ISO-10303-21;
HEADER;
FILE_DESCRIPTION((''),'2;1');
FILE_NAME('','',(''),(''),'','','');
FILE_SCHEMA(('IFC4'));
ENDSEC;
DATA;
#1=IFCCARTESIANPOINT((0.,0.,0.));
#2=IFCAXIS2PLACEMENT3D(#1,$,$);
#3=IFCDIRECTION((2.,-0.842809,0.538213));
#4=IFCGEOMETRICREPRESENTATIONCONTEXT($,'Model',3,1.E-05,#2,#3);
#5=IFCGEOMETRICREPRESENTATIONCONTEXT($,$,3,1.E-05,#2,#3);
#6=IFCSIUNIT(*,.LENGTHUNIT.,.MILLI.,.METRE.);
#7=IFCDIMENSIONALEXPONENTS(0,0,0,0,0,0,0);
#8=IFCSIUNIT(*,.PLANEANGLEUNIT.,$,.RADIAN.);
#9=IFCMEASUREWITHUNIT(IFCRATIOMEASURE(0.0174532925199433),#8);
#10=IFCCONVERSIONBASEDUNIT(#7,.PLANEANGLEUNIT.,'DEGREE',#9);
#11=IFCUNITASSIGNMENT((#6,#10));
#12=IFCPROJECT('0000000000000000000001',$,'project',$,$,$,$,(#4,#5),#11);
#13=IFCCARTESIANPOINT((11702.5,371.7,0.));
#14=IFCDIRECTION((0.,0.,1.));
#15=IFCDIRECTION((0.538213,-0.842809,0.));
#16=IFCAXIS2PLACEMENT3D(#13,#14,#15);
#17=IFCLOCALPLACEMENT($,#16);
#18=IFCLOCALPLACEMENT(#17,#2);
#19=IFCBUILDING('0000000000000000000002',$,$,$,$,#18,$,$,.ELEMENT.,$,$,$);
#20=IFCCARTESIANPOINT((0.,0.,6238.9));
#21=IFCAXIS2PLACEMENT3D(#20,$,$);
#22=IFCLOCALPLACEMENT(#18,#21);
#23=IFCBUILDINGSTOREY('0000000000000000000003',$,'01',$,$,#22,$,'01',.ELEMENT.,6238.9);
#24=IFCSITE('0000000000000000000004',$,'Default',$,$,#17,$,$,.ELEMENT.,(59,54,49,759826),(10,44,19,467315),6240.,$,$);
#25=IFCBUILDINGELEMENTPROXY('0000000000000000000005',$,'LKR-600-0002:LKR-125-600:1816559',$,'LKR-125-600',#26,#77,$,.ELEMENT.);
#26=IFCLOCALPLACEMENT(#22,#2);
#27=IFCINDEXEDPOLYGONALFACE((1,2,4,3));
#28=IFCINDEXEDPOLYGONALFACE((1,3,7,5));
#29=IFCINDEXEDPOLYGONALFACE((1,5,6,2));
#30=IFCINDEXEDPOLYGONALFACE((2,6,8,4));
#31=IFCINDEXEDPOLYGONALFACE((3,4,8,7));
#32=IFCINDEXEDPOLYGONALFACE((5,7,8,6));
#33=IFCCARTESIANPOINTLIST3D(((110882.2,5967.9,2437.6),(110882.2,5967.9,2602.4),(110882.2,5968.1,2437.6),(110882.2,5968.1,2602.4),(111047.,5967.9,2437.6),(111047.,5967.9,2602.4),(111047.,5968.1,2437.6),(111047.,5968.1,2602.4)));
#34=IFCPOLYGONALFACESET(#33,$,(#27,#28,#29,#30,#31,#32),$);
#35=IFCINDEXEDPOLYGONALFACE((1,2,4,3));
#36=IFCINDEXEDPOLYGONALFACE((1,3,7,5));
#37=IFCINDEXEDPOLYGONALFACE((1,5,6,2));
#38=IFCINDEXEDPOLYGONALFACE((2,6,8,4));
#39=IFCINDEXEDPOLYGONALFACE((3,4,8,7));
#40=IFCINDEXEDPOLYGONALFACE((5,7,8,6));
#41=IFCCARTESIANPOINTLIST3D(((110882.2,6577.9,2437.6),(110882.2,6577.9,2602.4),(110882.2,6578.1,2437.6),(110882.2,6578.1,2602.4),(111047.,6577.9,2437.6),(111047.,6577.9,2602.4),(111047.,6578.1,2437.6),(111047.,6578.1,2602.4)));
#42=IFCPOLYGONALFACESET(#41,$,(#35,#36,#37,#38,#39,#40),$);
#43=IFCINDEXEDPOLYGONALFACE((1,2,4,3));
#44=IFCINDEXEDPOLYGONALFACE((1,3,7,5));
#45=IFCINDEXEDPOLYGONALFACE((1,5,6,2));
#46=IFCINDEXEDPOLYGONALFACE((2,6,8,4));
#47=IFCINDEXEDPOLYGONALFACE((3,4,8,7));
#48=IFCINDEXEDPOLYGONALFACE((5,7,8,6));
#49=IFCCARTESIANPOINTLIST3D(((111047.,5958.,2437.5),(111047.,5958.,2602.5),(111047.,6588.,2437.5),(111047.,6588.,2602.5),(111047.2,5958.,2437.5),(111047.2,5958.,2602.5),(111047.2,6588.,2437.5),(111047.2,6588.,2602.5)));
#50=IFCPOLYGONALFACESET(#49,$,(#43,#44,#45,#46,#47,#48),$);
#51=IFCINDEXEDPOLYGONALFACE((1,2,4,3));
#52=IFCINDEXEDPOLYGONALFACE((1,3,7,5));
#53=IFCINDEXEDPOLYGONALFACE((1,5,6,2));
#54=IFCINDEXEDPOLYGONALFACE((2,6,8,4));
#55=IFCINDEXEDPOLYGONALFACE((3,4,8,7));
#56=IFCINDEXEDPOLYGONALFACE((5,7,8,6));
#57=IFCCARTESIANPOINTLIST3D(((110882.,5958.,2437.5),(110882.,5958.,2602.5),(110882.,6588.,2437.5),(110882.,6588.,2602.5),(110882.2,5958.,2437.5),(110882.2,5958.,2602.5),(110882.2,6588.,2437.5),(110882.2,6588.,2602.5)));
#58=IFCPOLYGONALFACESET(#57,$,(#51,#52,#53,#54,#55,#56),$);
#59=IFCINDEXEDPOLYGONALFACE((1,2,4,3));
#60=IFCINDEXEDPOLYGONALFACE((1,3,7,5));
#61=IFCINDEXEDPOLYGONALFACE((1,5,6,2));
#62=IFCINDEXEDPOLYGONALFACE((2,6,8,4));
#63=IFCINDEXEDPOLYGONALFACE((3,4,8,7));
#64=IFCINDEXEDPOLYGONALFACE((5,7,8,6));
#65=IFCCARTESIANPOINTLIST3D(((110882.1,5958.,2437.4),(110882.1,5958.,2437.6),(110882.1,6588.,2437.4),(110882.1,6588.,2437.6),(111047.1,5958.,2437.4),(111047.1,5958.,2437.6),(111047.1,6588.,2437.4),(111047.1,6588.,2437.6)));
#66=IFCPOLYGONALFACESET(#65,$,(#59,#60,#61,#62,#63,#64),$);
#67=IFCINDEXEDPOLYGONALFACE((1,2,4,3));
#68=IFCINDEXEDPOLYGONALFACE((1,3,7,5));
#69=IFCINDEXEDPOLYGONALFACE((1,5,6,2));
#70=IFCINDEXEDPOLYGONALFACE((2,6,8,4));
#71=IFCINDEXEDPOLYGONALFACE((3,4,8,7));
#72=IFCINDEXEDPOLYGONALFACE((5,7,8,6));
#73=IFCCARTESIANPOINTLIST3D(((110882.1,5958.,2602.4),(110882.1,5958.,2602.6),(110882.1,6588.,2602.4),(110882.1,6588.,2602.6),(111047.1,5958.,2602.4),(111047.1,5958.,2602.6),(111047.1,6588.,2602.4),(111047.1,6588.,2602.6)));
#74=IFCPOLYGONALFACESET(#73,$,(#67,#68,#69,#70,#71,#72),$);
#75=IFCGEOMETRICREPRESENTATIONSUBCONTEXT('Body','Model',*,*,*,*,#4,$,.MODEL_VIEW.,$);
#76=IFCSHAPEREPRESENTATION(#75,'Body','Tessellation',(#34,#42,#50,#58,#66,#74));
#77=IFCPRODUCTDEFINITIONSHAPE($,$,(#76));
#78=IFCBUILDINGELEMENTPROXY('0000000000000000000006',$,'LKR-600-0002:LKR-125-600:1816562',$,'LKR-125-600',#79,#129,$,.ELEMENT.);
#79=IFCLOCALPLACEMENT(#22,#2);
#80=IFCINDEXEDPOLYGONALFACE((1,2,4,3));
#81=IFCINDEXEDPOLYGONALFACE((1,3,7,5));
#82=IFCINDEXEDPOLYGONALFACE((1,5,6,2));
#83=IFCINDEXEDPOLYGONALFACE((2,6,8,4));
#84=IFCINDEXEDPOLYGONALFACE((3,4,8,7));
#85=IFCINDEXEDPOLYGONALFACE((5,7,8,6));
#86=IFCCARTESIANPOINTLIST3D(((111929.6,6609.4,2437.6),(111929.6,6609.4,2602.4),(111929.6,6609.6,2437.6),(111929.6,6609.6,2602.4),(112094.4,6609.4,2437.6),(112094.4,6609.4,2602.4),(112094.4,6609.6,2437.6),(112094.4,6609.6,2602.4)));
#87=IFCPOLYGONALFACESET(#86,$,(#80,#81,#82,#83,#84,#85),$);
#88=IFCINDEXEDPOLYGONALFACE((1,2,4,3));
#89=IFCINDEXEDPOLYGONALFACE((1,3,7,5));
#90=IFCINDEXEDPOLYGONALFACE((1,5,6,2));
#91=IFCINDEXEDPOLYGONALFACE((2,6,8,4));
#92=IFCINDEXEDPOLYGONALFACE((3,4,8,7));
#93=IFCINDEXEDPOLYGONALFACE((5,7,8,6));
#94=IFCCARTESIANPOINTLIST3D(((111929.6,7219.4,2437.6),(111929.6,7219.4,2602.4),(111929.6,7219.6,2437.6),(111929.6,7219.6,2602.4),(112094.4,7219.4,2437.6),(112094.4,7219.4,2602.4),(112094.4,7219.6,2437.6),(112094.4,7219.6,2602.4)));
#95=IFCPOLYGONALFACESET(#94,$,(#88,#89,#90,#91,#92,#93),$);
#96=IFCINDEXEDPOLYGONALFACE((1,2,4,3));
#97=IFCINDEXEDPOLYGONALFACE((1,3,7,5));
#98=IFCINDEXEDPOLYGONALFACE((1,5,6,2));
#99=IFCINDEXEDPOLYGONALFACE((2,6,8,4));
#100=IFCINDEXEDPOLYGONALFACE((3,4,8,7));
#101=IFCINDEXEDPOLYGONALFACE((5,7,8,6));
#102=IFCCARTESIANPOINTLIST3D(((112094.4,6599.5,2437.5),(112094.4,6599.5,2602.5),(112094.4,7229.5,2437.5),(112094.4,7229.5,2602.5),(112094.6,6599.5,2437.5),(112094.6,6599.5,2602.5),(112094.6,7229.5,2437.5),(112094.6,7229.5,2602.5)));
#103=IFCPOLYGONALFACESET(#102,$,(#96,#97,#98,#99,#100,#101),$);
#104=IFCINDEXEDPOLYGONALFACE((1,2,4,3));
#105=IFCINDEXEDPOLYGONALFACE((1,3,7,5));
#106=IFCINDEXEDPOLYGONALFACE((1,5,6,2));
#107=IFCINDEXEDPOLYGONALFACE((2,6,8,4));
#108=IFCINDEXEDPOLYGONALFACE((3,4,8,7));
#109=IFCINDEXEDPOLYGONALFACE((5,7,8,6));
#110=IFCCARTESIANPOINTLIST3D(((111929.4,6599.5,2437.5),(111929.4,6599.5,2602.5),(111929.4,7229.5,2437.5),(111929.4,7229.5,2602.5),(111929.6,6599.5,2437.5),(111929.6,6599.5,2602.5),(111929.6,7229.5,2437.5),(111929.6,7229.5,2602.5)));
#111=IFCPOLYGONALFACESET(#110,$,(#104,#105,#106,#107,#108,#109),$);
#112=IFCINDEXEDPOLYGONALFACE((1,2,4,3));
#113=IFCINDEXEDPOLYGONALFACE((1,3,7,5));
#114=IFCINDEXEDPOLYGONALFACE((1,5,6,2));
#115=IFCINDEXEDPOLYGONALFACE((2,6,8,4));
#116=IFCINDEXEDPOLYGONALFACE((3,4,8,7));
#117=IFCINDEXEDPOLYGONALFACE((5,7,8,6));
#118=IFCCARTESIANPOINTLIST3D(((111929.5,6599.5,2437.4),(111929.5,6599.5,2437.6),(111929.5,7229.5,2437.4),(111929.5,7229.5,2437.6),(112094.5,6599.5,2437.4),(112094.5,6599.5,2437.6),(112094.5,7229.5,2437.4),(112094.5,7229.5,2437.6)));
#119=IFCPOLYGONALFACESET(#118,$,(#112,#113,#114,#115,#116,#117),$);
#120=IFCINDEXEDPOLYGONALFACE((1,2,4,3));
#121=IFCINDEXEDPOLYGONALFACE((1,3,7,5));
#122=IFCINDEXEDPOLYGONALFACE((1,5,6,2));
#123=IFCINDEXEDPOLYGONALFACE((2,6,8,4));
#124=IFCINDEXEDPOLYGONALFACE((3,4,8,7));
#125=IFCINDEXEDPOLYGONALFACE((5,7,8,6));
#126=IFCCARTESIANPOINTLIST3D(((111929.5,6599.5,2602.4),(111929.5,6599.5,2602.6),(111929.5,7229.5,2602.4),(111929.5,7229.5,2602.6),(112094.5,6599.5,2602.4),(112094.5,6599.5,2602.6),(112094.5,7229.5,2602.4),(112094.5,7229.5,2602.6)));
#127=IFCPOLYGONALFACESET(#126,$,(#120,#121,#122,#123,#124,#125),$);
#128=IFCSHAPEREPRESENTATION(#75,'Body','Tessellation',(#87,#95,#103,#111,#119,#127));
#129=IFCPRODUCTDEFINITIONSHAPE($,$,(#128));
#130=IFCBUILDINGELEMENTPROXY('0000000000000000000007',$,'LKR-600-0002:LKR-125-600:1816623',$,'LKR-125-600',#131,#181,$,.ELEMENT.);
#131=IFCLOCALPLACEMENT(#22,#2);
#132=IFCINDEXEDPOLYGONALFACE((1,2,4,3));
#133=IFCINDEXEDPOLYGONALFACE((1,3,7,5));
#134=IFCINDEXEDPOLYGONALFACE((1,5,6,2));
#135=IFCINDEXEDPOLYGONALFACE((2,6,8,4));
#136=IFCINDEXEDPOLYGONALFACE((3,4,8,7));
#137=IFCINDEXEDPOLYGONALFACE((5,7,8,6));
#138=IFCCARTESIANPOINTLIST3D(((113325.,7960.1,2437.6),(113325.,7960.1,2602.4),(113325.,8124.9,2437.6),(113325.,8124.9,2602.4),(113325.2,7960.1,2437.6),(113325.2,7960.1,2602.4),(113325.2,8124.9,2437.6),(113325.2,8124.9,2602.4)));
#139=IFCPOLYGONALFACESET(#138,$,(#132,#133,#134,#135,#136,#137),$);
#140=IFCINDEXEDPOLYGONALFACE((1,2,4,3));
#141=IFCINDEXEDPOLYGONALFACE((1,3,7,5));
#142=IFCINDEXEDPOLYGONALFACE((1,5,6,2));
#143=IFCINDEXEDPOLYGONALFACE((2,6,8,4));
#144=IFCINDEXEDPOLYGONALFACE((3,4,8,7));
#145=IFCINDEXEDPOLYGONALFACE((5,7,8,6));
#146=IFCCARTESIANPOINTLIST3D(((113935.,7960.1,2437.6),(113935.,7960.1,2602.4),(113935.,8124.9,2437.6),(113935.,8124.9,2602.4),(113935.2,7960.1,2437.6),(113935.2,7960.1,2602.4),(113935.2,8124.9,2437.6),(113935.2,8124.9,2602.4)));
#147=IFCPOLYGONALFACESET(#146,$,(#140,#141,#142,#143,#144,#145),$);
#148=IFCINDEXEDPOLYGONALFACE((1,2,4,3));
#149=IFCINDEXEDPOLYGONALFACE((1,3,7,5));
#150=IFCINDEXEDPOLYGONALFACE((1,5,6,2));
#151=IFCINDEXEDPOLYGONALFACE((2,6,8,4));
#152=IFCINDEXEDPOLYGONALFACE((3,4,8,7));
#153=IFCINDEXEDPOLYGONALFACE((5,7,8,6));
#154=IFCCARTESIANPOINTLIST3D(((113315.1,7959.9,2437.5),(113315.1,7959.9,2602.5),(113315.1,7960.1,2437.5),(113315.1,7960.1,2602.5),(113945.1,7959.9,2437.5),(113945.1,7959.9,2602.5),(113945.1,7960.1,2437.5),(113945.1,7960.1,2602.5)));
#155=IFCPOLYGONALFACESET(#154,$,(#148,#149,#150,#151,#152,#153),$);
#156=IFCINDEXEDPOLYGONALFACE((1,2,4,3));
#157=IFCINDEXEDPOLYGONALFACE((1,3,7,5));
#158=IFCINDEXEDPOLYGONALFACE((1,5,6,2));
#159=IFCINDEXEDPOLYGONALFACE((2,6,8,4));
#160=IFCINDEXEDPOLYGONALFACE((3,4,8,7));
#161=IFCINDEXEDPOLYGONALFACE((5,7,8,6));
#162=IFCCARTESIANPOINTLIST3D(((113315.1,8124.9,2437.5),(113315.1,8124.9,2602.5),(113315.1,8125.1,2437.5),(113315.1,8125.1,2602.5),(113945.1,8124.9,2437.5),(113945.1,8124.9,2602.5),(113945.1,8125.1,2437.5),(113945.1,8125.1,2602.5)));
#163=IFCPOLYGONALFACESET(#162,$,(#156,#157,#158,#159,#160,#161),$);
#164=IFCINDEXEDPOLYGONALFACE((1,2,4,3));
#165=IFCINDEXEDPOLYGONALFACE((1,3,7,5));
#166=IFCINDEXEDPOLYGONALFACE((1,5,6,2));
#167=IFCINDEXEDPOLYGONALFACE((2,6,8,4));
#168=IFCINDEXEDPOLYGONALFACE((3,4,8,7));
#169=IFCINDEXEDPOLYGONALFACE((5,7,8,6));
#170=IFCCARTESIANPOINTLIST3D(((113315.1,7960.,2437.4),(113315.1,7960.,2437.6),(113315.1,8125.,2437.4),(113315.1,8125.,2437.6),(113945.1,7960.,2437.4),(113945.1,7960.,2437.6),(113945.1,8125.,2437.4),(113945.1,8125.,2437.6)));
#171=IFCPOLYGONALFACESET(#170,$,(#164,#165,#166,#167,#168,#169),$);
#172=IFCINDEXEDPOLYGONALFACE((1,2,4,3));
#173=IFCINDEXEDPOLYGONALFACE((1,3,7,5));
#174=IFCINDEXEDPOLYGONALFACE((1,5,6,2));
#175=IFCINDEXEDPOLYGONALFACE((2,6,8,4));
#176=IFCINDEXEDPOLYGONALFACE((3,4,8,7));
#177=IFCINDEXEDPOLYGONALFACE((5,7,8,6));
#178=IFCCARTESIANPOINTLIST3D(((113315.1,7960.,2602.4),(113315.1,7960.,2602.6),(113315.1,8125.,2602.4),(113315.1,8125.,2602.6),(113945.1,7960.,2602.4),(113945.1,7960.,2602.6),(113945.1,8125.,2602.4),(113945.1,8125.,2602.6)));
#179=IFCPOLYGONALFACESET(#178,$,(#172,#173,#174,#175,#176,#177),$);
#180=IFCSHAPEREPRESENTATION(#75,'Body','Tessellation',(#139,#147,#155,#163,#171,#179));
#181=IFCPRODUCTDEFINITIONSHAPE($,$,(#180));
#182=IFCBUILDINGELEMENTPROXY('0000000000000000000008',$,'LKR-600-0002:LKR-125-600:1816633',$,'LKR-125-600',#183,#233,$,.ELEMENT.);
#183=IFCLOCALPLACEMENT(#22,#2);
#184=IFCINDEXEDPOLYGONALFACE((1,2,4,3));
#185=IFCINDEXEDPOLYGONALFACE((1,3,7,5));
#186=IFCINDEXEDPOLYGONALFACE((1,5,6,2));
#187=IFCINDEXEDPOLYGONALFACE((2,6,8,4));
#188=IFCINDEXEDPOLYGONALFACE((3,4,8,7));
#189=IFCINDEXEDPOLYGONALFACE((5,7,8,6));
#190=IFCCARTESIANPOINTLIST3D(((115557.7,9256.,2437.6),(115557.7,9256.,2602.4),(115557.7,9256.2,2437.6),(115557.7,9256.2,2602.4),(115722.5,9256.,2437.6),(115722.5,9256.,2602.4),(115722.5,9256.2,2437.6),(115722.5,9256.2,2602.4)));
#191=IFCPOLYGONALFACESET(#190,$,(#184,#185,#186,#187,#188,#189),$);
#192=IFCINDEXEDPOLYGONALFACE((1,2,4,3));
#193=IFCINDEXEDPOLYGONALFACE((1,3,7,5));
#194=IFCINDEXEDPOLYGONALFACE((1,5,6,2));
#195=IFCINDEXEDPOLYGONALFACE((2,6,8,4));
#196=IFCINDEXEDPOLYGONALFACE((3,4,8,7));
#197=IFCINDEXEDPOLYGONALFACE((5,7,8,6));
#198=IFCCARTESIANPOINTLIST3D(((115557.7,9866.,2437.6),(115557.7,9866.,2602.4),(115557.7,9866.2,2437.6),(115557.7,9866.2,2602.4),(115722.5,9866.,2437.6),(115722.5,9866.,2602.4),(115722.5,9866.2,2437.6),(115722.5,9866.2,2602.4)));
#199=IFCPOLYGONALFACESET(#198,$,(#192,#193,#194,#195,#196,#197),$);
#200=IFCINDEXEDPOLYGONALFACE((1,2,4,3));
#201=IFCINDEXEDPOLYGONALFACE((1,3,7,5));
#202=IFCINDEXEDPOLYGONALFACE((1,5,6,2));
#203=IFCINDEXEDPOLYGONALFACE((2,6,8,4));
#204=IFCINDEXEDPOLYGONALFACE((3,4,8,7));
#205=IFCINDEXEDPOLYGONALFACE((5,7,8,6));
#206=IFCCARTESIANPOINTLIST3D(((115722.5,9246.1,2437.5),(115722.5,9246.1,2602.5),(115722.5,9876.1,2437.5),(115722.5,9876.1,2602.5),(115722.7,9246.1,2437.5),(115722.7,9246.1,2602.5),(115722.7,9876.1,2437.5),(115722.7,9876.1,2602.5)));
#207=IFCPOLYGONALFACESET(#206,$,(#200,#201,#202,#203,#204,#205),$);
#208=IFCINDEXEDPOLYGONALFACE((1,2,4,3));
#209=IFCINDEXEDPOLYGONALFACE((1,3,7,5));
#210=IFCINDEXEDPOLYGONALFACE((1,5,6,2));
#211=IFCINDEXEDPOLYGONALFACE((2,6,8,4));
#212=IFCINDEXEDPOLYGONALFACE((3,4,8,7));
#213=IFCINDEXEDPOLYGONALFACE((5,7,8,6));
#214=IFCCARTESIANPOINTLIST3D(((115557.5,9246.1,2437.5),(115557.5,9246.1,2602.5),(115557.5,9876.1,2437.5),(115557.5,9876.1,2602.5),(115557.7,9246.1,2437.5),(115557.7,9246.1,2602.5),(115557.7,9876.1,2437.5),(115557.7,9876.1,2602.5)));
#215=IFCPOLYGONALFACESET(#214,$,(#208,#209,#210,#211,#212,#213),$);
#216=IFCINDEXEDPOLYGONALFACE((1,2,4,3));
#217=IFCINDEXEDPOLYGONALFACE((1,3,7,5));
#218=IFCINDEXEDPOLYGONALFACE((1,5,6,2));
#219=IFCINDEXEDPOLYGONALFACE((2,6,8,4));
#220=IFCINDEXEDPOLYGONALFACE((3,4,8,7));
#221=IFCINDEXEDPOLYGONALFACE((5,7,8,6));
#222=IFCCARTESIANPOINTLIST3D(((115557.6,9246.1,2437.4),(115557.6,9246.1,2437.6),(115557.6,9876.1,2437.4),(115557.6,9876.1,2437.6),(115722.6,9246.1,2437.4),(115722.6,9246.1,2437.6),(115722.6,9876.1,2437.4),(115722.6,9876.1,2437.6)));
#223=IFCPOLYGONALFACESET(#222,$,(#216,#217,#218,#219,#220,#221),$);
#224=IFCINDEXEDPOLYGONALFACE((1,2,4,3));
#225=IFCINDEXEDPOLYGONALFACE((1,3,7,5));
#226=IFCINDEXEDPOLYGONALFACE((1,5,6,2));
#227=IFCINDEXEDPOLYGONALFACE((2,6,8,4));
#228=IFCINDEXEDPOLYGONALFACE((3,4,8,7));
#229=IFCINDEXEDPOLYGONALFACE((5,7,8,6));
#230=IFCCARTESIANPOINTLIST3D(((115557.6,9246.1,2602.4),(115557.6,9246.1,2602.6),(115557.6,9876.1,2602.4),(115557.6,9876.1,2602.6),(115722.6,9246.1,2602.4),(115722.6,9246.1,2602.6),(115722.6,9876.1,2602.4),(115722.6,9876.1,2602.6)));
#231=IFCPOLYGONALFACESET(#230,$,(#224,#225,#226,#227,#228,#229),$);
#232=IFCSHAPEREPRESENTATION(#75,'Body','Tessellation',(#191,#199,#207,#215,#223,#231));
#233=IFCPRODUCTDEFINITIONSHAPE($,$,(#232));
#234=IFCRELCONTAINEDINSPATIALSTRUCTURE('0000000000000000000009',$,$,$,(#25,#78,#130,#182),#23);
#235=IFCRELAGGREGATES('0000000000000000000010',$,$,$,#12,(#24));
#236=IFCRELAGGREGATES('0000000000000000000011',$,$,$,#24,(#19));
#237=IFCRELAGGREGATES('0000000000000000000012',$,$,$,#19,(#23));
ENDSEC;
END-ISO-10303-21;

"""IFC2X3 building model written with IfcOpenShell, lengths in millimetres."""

from ifc_helpers import new_model, entity, si_unit, converted_unit, direction, frame, frame_2d, origin, place, context, subcontext, project, spatial, rectangle, extrude, source, transform, mapped, element, save


model = new_model("IFC2X3")

# Units and contexts
model_context = context("Model", 3, precision=1e-05, world=origin(), true_north=direction((2.0, -0.842809, 0.538213)))
context_of_model = context(None, 3, precision=1e-05, world=origin(), true_north=direction((2.0, -0.842809, 0.538213)))
body_context = subcontext(model_context, "Body", "Model", "MODEL_VIEW")
ifc_project = project(units=[si_unit("LENGTHUNIT", "METRE", prefix="MILLI"), converted_unit("PLANEANGLEUNIT", "DEGREE", entity("IfcRatioMeasure", 0.0174532925199433), si_unit("PLANEANGLEUNIT", "RADIAN"), dimensions=[0, 0, 0, 0, 0, 0, 0])], contexts=[model_context, context_of_model])

# Site, building, storey
site_placement = place(None, frame((11702.5, 371.7, 0.0), z_axis=(0.0, 0.0, 1.0), x_axis=(0.538213, -0.842809, 0.0)))
site = spatial("IfcSite", under=ifc_project, at=site_placement, Name="Default", CompositionType="ELEMENT", RefLatitude=(59, 54, 49, 759826), RefLongitude=(10, 44, 19, 467315), RefElevation=6240.0)
building_placement = place(site_placement, origin())
building = spatial("IfcBuilding", under=site, at=building_placement, CompositionType="ELEMENT")
storey_placement = place(building_placement, frame((0.0, 0.0, 6238.9)))
storey = spatial("IfcBuildingStorey", under=building, at=storey_placement, Name="01", LongName="01", CompositionType="ELEMENT", Elevation=6238.9)

# Building element proxies
shared_shape_1 = source(origin(), body_context, "Body", "SweptSolid", [
    extrude(rectangle(XDim=0.2, YDim=164.8, at=frame_2d((0.0, 0.0), x_axis=(1.0, 0.0))), frame((305.0, 0.0, -82.4)), (0.0, 0.0, 1.0), 164.8),
    extrude(rectangle(XDim=0.2, YDim=164.8, at=frame_2d((0.0, 0.0), x_axis=(1.0, 0.0))), frame((-305.0, 0.0, -82.4)), (0.0, 0.0, 1.0), 164.8),
    extrude(rectangle(XDim=0.2, YDim=630.0, at=frame_2d((0.0, 0.0), x_axis=(1.0, 0.0))), frame((0.0, 82.5, -82.5), z_axis=(0.0, 0.0, 1.0), x_axis=(0.0, 1.0, 0.0)), (0.0, 0.0, 1.0), 165.0),
    extrude(rectangle(XDim=0.2, YDim=630.0, at=frame_2d((0.0, 0.0), x_axis=(1.0, 0.0))), frame((0.0, -82.5, -82.5), z_axis=(0.0, 0.0, 1.0), x_axis=(0.0, 1.0, 0.0)), (0.0, 0.0, 1.0), 165.0),
    extrude(rectangle(XDim=165.0, YDim=630.0, at=frame_2d((0.0, 0.0), x_axis=(1.0, 0.0))), frame((0.0, 0.0, -82.6), z_axis=(0.0, 0.0, 1.0), x_axis=(0.0, -1.0, 0.0)), (0.0, 0.0, 1.0), 0.2),
    extrude(rectangle(XDim=165.0, YDim=630.0, at=frame_2d((0.0, 0.0), x_axis=(1.0, 0.0))), frame((0.0, 0.0, 82.4), z_axis=(0.0, 0.0, 1.0), x_axis=(0.0, -1.0, 0.0)), (0.0, 0.0, 1.0), 0.2),
])
for number, where, z_axis, x_axis, name in (
    (1, (110964.6, 6273.0, 2520.0), (0.0, 0.0, 1.0), (0.0, -1.0, 0.0), "LKR-600-0002:LKR-125-600:1816559"),
    (2, (112012.0, 6914.5, 2520.0), (0.0, 0.0, 1.0), (-0.000003, -1.0, 0.0), "LKR-600-0002:LKR-125-600:1816562"),
    (3, (113630.1, 8042.5, 2520.0), (0.0, 0.0, 1.0), (-1.0, 0.0, 0.0), "LKR-600-0002:LKR-125-600:1816623"),
    (4, (115640.1, 9561.1, 2520.0), (0.0, 0.0, 1.0), (-0.000003, -1.0, 0.0), "LKR-600-0002:LKR-125-600:1816633"),
):
    element("IfcBuildingElementProxy", number, at=place(storey_placement, frame(where, z_axis=z_axis, x_axis=x_axis)), inside=storey, Name=name, ObjectType="LKR-125-600", CompositionType="ELEMENT", context=body_context, shape_type="MappedRepresentation", body=[
        mapped(shared_shape_1, transform((0.0, 0.0, 0.0), scale=1.0)),
    ])

save(model, "model.ifc")
